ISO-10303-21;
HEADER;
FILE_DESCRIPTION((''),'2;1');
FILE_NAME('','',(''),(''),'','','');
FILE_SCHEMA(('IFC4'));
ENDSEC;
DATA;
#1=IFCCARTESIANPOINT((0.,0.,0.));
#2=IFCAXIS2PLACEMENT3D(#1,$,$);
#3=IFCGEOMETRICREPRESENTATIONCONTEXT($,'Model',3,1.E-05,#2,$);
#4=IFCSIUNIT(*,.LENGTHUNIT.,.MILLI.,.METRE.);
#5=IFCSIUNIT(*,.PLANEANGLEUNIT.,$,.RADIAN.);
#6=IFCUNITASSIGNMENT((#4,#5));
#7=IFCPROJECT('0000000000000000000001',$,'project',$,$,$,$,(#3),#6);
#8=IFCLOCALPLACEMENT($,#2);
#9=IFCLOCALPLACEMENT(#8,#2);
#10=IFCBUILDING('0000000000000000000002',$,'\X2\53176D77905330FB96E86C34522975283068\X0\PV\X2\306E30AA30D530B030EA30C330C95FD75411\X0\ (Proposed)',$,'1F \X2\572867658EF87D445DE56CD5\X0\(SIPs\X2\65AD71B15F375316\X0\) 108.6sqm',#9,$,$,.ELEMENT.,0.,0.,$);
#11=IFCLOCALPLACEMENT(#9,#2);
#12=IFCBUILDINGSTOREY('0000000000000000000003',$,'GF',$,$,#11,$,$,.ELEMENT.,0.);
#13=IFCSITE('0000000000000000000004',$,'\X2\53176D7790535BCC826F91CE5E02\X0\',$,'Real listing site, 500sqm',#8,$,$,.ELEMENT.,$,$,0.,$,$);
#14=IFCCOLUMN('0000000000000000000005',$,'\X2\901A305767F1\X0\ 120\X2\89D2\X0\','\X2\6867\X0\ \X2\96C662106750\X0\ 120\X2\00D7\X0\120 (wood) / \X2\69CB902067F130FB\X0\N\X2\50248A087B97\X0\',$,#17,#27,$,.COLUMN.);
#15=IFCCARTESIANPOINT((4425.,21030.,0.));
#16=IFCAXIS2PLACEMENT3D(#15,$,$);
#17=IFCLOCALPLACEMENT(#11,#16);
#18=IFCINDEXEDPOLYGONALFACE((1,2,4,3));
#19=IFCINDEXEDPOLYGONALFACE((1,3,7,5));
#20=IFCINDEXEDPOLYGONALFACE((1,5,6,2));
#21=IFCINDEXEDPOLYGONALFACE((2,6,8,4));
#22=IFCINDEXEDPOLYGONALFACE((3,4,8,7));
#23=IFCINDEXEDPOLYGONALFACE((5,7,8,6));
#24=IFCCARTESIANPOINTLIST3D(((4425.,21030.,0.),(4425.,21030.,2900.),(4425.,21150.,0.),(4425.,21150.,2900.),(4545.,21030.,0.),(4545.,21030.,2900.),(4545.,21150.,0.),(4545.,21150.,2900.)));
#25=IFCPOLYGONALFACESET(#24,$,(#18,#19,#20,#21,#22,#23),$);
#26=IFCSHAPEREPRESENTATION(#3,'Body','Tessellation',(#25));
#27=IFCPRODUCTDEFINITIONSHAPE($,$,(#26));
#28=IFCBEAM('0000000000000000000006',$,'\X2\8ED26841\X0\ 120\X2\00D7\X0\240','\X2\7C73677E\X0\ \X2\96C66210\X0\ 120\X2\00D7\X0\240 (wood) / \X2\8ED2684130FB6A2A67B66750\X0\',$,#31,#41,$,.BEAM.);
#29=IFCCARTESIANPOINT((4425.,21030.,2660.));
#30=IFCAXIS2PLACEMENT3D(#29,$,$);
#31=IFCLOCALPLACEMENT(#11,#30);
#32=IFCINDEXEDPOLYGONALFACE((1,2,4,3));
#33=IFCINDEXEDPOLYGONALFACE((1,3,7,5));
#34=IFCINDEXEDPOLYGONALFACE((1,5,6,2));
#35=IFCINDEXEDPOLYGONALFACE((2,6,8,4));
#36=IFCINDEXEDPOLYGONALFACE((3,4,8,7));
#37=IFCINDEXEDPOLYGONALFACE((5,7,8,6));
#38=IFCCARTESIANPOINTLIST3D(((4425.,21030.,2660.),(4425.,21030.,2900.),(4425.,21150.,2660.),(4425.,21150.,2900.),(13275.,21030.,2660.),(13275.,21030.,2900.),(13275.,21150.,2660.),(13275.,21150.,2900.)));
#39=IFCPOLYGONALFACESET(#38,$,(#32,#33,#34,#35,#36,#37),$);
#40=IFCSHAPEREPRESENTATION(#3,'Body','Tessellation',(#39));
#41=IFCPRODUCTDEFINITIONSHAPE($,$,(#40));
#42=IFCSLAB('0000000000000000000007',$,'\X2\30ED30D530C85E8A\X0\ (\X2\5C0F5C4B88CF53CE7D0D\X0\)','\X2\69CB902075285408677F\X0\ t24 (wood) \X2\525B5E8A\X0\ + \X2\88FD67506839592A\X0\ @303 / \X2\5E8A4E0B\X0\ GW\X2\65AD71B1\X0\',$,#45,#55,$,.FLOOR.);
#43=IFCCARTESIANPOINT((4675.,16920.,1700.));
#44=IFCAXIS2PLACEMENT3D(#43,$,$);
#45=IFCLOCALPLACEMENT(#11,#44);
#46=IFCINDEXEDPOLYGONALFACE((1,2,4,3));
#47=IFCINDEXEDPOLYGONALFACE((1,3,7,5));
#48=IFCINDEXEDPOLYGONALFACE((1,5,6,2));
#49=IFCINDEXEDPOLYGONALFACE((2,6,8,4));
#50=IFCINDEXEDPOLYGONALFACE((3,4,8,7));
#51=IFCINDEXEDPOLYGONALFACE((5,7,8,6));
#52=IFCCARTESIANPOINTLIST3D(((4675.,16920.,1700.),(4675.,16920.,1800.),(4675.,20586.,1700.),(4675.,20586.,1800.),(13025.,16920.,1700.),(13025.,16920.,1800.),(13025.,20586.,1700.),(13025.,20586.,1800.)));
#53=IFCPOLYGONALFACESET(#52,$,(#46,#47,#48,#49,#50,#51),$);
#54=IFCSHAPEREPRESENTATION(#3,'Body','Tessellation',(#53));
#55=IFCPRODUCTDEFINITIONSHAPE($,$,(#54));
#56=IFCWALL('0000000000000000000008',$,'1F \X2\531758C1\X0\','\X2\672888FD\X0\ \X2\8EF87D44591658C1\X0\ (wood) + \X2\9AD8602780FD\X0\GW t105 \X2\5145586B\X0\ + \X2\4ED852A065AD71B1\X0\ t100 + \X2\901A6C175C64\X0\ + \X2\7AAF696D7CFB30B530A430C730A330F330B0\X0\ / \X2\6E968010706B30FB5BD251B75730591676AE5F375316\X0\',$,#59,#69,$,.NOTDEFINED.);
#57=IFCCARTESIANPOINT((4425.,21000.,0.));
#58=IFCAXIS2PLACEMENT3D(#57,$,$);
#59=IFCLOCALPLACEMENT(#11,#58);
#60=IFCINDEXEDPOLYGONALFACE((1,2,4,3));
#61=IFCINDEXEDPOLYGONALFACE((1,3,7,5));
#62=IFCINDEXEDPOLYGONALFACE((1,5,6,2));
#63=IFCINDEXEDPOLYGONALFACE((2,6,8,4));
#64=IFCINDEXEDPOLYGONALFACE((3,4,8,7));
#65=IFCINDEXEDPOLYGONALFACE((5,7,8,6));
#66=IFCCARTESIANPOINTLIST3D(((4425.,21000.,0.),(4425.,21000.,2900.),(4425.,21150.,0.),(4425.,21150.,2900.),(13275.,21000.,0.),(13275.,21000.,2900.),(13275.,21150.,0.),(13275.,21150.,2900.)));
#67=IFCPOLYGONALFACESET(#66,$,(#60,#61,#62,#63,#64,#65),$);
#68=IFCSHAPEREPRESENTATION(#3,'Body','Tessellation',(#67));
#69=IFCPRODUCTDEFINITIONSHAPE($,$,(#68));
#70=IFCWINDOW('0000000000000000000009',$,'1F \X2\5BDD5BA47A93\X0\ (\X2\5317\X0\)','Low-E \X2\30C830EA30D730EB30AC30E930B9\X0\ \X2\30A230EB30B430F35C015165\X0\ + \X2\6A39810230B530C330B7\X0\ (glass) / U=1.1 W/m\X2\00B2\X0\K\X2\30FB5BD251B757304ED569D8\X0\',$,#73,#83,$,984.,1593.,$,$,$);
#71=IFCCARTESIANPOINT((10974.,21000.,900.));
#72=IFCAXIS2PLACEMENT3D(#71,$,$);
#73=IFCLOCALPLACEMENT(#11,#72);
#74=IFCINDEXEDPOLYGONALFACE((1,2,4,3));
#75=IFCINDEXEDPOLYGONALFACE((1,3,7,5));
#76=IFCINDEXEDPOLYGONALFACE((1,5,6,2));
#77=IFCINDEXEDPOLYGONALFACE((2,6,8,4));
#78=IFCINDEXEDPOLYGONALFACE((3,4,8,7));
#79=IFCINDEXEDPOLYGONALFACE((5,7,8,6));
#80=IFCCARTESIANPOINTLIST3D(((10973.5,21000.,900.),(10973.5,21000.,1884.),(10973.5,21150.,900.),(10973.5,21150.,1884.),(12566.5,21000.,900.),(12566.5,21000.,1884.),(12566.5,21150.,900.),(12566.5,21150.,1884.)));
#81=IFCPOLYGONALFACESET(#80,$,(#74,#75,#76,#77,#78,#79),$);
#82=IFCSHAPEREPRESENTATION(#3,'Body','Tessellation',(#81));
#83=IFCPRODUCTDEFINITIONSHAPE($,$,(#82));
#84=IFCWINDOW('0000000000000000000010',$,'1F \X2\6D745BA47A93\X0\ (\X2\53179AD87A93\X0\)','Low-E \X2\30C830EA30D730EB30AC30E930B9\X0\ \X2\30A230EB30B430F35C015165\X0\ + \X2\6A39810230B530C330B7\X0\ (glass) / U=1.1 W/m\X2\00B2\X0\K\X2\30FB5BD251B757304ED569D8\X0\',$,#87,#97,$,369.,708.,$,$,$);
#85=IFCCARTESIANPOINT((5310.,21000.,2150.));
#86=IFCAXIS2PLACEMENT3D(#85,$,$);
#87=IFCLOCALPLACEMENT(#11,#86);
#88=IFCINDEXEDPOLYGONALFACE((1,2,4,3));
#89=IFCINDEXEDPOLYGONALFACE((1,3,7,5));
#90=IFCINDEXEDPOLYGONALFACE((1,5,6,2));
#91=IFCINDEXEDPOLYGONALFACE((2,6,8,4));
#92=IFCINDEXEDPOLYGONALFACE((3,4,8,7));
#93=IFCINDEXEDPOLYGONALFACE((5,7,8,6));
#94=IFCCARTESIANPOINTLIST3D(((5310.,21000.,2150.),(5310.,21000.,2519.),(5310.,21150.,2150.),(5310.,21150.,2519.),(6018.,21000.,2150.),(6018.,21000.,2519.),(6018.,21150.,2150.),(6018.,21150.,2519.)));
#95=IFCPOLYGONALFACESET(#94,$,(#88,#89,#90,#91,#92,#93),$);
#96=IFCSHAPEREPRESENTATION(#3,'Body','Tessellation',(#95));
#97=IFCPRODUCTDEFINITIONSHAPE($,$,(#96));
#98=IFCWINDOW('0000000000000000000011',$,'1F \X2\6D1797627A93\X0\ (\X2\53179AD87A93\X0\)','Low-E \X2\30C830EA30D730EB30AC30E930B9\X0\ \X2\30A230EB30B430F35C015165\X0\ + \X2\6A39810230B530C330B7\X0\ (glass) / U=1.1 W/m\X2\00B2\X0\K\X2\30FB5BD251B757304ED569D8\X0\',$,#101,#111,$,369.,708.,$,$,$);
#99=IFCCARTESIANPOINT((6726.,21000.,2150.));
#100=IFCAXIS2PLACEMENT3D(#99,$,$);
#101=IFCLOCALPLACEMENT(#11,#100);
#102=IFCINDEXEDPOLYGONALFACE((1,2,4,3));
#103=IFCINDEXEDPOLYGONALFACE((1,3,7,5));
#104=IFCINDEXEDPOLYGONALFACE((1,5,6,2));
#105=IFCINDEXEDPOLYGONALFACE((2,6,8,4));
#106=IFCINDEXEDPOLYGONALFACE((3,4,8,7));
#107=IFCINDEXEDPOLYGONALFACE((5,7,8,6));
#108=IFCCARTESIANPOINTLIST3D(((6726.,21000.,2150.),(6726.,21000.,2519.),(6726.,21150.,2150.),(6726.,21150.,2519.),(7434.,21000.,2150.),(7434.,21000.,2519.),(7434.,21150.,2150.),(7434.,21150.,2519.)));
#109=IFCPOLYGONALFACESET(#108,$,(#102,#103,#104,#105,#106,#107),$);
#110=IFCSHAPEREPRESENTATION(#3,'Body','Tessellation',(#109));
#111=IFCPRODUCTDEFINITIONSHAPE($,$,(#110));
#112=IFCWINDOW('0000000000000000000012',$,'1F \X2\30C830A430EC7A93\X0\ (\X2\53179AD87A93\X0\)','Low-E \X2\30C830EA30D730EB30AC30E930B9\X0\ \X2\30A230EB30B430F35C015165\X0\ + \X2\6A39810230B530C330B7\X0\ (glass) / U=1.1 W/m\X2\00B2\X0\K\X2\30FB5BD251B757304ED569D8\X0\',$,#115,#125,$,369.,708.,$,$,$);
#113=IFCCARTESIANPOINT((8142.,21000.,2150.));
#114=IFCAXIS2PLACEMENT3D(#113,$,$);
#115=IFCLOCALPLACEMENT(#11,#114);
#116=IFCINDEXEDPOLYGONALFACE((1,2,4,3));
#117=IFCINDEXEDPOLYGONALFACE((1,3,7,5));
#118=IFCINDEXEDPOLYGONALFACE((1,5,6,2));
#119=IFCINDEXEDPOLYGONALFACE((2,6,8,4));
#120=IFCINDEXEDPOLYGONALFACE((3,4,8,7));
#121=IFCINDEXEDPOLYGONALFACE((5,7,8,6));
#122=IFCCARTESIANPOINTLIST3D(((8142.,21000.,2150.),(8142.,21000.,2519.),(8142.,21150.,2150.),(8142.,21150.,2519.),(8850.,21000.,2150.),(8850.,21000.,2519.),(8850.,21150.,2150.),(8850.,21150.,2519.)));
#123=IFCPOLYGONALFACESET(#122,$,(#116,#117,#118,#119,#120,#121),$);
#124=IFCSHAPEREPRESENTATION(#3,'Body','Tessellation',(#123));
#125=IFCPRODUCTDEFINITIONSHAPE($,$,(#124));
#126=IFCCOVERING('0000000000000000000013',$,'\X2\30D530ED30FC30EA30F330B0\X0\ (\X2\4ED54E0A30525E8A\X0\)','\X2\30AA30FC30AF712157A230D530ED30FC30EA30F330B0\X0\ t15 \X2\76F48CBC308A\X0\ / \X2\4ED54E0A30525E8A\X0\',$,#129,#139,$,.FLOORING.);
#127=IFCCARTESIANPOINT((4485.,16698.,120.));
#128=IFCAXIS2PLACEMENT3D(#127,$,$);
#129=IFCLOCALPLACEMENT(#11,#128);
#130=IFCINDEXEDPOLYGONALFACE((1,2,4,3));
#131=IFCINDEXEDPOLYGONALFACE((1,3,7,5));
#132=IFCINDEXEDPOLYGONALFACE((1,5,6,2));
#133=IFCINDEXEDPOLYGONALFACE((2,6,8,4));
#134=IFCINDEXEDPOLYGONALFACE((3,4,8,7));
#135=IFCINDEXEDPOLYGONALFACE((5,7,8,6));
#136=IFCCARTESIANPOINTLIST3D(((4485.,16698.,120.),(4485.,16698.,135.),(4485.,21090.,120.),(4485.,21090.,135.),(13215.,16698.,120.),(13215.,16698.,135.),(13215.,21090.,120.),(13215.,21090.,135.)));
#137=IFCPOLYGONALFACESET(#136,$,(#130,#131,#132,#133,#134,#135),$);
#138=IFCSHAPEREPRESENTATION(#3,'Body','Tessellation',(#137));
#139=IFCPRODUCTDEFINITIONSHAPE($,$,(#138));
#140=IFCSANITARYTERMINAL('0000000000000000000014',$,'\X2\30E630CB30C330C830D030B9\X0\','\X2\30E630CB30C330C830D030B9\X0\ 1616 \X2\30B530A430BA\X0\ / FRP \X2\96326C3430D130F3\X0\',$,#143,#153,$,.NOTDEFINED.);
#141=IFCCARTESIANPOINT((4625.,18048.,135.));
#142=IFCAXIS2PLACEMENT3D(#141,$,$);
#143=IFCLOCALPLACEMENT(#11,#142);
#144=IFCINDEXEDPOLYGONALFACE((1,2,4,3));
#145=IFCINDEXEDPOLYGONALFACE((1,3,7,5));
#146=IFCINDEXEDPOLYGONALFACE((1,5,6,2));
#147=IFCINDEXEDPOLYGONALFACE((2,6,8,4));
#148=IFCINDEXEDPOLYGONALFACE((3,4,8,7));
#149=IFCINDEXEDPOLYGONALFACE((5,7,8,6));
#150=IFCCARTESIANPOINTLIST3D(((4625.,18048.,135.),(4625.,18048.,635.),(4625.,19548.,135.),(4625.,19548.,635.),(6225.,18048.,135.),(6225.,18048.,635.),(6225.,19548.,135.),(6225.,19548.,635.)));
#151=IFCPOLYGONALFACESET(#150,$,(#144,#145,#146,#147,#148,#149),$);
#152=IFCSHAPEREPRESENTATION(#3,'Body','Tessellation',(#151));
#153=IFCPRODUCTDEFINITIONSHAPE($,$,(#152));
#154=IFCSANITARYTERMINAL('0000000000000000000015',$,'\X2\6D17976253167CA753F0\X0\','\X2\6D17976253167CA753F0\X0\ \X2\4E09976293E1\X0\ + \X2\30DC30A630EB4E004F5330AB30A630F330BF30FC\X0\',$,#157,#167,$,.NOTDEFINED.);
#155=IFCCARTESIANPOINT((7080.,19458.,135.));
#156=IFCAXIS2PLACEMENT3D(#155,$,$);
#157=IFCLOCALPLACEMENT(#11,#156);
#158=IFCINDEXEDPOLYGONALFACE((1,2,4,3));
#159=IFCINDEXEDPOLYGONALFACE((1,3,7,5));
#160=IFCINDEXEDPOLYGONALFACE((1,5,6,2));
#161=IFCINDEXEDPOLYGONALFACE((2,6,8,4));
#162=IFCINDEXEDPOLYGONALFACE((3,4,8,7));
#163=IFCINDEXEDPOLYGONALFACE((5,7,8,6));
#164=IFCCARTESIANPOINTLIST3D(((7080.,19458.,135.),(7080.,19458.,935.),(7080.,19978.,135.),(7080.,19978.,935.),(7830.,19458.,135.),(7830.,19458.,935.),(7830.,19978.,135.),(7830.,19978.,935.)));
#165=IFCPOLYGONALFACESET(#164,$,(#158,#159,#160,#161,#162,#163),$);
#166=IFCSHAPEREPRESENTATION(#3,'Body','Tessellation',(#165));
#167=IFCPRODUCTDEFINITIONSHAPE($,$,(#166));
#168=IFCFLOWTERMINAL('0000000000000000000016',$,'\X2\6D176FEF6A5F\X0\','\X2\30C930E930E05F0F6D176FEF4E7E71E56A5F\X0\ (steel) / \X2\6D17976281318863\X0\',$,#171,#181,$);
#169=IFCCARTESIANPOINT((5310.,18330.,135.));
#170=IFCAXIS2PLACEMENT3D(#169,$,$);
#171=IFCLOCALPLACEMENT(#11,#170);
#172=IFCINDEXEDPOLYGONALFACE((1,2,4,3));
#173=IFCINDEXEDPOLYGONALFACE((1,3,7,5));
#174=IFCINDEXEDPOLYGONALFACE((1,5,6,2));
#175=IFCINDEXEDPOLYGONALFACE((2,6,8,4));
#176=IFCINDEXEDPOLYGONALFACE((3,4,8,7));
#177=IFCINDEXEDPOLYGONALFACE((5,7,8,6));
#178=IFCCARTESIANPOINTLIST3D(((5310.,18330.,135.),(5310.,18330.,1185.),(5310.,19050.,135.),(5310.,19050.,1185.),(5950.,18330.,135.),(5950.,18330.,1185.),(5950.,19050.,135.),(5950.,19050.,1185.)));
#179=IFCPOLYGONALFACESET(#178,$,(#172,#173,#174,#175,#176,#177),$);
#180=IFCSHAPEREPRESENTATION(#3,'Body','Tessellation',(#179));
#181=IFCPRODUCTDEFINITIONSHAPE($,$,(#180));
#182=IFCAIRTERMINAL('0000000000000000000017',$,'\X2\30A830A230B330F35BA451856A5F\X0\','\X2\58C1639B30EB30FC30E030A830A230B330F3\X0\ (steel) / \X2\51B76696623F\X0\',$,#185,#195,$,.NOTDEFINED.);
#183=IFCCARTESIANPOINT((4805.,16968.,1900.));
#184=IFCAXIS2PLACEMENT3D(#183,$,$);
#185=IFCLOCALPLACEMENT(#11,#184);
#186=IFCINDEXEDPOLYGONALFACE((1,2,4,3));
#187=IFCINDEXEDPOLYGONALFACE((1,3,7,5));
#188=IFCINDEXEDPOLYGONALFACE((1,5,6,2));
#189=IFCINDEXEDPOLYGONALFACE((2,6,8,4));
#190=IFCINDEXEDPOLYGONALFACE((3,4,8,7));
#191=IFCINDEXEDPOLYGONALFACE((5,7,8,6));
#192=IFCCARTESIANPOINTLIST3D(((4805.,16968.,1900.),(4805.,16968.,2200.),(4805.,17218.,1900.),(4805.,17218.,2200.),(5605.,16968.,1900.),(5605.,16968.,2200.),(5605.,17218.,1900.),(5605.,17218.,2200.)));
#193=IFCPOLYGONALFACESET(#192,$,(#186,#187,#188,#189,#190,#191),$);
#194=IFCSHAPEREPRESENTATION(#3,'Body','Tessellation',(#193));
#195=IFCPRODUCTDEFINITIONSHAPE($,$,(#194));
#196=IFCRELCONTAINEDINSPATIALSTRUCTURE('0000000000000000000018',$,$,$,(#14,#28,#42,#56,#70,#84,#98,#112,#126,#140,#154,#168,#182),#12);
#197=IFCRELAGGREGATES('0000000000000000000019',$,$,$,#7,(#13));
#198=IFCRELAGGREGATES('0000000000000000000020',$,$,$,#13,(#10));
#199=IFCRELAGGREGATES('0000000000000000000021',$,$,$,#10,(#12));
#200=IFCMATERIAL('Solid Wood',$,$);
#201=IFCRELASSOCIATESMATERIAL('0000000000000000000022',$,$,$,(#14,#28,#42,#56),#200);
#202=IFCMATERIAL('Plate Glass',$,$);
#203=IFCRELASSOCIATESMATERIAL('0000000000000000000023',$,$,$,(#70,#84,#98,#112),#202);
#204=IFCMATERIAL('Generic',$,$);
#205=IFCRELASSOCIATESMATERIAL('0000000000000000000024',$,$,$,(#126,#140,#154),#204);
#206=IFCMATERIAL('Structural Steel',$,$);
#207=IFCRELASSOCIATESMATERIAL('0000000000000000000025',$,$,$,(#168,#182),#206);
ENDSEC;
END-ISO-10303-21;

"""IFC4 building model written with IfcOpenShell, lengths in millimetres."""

from ifc_helpers import new_model, si_unit, frame, frame_2d, origin, place, context, project, spatial, rectangle, extrude, material, element, fill, save


model = new_model("IFC4")

# Units and contexts
model_context = context("Model", 3, precision=1e-05, world=origin())
ifc_project = project(units=[si_unit("LENGTHUNIT", "METRE", prefix="MILLI"), si_unit("PLANEANGLEUNIT", "RADIAN")], contexts=[model_context])

# Site, building, storey
site_placement = place(None, origin())
site = spatial("IfcSite", under=ifc_project, at=site_placement, Name="北海道富良野市", ObjectType="Real listing site, 500sqm", CompositionType="ELEMENT", RefElevation=0.0)
building_placement = place(site_placement, origin())
building = spatial("IfcBuilding", under=site, at=building_placement, Name="北海道・雨水利用とPVのオフグリッド志向 (Proposed)", ObjectType="1F 在来軸組工法(SIPs断熱強化) 108.6sqm", CompositionType="ELEMENT", ElevationOfRefHeight=0.0, ElevationOfTerrain=0.0)
storey_placement = place(building_placement, origin())
storey = spatial("IfcBuildingStorey", under=building, at=storey_placement, Name="GF", CompositionType="ELEMENT", Elevation=0.0)

# Column
ifc_material_1 = material(Name="Solid Wood")
column_1_placement = place(storey_placement, frame((4425.0, 21030.0, 0.0)))
element("IfcColumn", 1, at=column_1_placement, inside=storey, material=ifc_material_1, Name="通し柱 120角", Description="桧 集成材 120×120 (wood) / 構造柱・N値計算", PredefinedType="COLUMN", context=model_context, shape_type="SweptSolid", body=[
    extrude(rectangle(XDim=120.0, YDim=120.0, at=frame_2d((60.0, 60.0))), frame((4425.0, 21030.0, 0.0)), (0.0, 0.0, 1.0), 2900.0),
])

# Beam
beam_1_placement = place(storey_placement, frame((4425.0, 21030.0, 2660.0)))
element("IfcBeam", 2, at=beam_1_placement, inside=storey, material=ifc_material_1, Name="軒桁 120×240", Description="米松 集成 120×240 (wood) / 軒桁・横架材", PredefinedType="BEAM", context=model_context, shape_type="SweptSolid", body=[
    extrude(rectangle(XDim=8850.0, YDim=120.0, at=frame_2d((4425.0, 60.0))), frame((4425.0, 21030.0, 2660.0)), (0.0, 0.0, 1.0), 240.0),
])

# Slab
slab_placement = place(storey_placement, frame((4675.0, 16920.0, 1700.0)))
element("IfcSlab", 3, at=slab_placement, inside=storey, material=ifc_material_1, Name="ロフト床 (小屋裏収納)", Description="構造用合板 t24 (wood) 剛床 + 製材根太 @303 / 床下 GW断熱", PredefinedType="FLOOR", context=model_context, shape_type="SweptSolid", body=[
    extrude(rectangle(XDim=8350.0, YDim=3666.0, at=frame_2d((4175.0, 1833.0))), frame((4675.0, 16920.0, 1700.0)), (0.0, 0.0, 1.0), 100.0),
])

# Wall, openings, windows
wall_1_placement = place(storey_placement, frame((4425.0, 21000.0, 0.0)))
wall_1 = element("IfcWall", 4, at=wall_1_placement, inside=storey, material=ifc_material_1, Name="1F 北壁", Description="木製 軸組外壁 (wood) + 高性能GW t105 充填 + 付加断熱 t100 + 通気層 + 窯業系サイディング / 準耐火・寒冷地外皮強化", PredefinedType="NOTDEFINED", context=model_context, shape_type="SweptSolid", body=[
    extrude(rectangle(XDim=8850.0, YDim=150.0, at=frame_2d((4425.0, 75.0))), frame((4425.0, 21000.0, 0.0)), (0.0, 0.0, 1.0), 2900.0),
])
opening_1_placement = place(storey_placement, frame((10974.0, 21000.0, 900.0)))
opening_1 = element("IfcOpeningElement", 5, at=opening_1_placement, cuts=wall_1, PredefinedType="NOTDEFINED", context=model_context, shape_type="SweptSolid", body=[
    extrude(rectangle(XDim=1593.0, YDim=150.0, at=frame_2d((796.0, 75.0))), frame((10974.0, 21000.0, 900.0)), (0.0, 0.0, 1.0), 984.0),
])
opening_2_placement = place(storey_placement, frame((5310.0, 21000.0, 2150.0)))
opening_2 = element("IfcOpeningElement", 6, at=opening_2_placement, cuts=wall_1, PredefinedType="NOTDEFINED", context=model_context, shape_type="SweptSolid", body=[
    extrude(rectangle(XDim=708.0, YDim=150.0, at=frame_2d((354.0, 75.0))), frame((5310.0, 21000.0, 2150.0)), (0.0, 0.0, 1.0), 369.0),
])
opening_3_placement = place(storey_placement, frame((6726.0, 21000.0, 2150.0)))
opening_3 = element("IfcOpeningElement", 7, at=opening_3_placement, cuts=wall_1, PredefinedType="NOTDEFINED", context=model_context, shape_type="SweptSolid", body=[
    extrude(rectangle(XDim=708.0, YDim=150.0, at=frame_2d((354.0, 75.0))), frame((6726.0, 21000.0, 2150.0)), (0.0, 0.0, 1.0), 369.0),
])
opening_4_placement = place(storey_placement, frame((8142.0, 21000.0, 2150.0)))
opening_4 = element("IfcOpeningElement", 8, at=opening_4_placement, cuts=wall_1, PredefinedType="NOTDEFINED", context=model_context, shape_type="SweptSolid", body=[
    extrude(rectangle(XDim=708.0, YDim=150.0, at=frame_2d((354.0, 75.0))), frame((8142.0, 21000.0, 2150.0)), (0.0, 0.0, 1.0), 369.0),
])
ifc_material_2 = material(Name="Plate Glass")
window_1_placement = place(storey_placement, frame((10974.0, 21000.0, 900.0)))
window_1 = element("IfcWindow", 9, at=window_1_placement, inside=storey, material=ifc_material_2, Name="1F 寝室窓 (北)", Description="Low-E トリプルガラス アルゴン封入 + 樹脂サッシ (glass) / U=1.1 W/m²K・寒冷地仕様", OverallHeight=984.0, OverallWidth=1593.0, context=model_context, shape_type="SweptSolid", body=[
    extrude(rectangle(XDim=1593.0, YDim=150.0, at=frame_2d((796.0, 75.0))), frame((10974.0, 21000.0, 900.0)), (0.0, 0.0, 1.0), 984.0),
])
fill(opening_1, window_1)
window_2_placement = place(storey_placement, frame((5310.0, 21000.0, 2150.0)))
window_2 = element("IfcWindow", 10, at=window_2_placement, inside=storey, material=ifc_material_2, Name="1F 浴室窓 (北高窓)", Description="Low-E トリプルガラス アルゴン封入 + 樹脂サッシ (glass) / U=1.1 W/m²K・寒冷地仕様", OverallHeight=369.0, OverallWidth=708.0, context=model_context, shape_type="SweptSolid", body=[
    extrude(rectangle(XDim=708.0, YDim=150.0, at=frame_2d((354.0, 75.0))), frame((5310.0, 21000.0, 2150.0)), (0.0, 0.0, 1.0), 369.0),
])
fill(opening_2, window_2)
window_3_placement = place(storey_placement, frame((6726.0, 21000.0, 2150.0)))
window_3 = element("IfcWindow", 11, at=window_3_placement, inside=storey, material=ifc_material_2, Name="1F 洗面窓 (北高窓)", Description="Low-E トリプルガラス アルゴン封入 + 樹脂サッシ (glass) / U=1.1 W/m²K・寒冷地仕様", OverallHeight=369.0, OverallWidth=708.0, context=model_context, shape_type="SweptSolid", body=[
    extrude(rectangle(XDim=708.0, YDim=150.0, at=frame_2d((354.0, 75.0))), frame((6726.0, 21000.0, 2150.0)), (0.0, 0.0, 1.0), 369.0),
])
fill(opening_3, window_3)
window_4_placement = place(storey_placement, frame((8142.0, 21000.0, 2150.0)))
window_4 = element("IfcWindow", 12, at=window_4_placement, inside=storey, material=ifc_material_2, Name="1F トイレ窓 (北高窓)", Description="Low-E トリプルガラス アルゴン封入 + 樹脂サッシ (glass) / U=1.1 W/m²K・寒冷地仕様", OverallHeight=369.0, OverallWidth=708.0, context=model_context, shape_type="SweptSolid", body=[
    extrude(rectangle(XDim=708.0, YDim=150.0, at=frame_2d((354.0, 75.0))), frame((8142.0, 21000.0, 2150.0)), (0.0, 0.0, 1.0), 369.0),
])
fill(opening_4, window_4)

# Covering
ifc_material_3 = material(Name="Generic")
covering_placement = place(storey_placement, frame((4485.0, 16698.0, 120.0)))
element("IfcCovering", 13, at=covering_placement, inside=storey, material=ifc_material_3, Name="フローリング (仕上げ床)", Description="オーク無垢フローリング t15 直貼り / 仕上げ床", PredefinedType="FLOORING", context=model_context, shape_type="SweptSolid", body=[
    extrude(rectangle(XDim=8730.0, YDim=4392.0, at=frame_2d((4365.0, 2196.0))), frame((4485.0, 16698.0, 120.0)), (0.0, 0.0, 1.0), 15.0),
])

# Sanitary terminals
sanitary_terminal_1_placement = place(storey_placement, frame((4625.0, 18048.0, 135.0)))
element("IfcSanitaryTerminal", 14, at=sanitary_terminal_1_placement, inside=storey, material=ifc_material_3, Name="ユニットバス", Description="ユニットバス 1616 サイズ / FRP 防水パン", PredefinedType="NOTDEFINED", context=model_context, shape_type="SweptSolid", body=[
    extrude(rectangle(XDim=1600.0, YDim=1500.0, at=frame_2d((800.0, 750.0))), frame((4625.0, 18048.0, 135.0)), (0.0, 0.0, 1.0), 500.0),
])
sanitary_terminal_2_placement = place(storey_placement, frame((7080.0, 19458.0, 135.0)))
element("IfcSanitaryTerminal", 15, at=sanitary_terminal_2_placement, inside=storey, material=ifc_material_3, Name="洗面化粧台", Description="洗面化粧台 三面鏡 + ボウル一体カウンター", PredefinedType="NOTDEFINED", context=model_context, shape_type="SweptSolid", body=[
    extrude(rectangle(XDim=750.0, YDim=520.0, at=frame_2d((375.0, 260.0))), frame((7080.0, 19458.0, 135.0)), (0.0, 0.0, 1.0), 800.0),
])

# Flow terminal
ifc_material_4 = material(Name="Structural Steel")
flow_terminal_placement = place(storey_placement, frame((5310.0, 18330.0, 135.0)))
element("IfcFlowTerminal", 16, at=flow_terminal_placement, inside=storey, material=ifc_material_4, Name="洗濯機", Description="ドラム式洗濯乾燥機 (steel) / 洗面脱衣", context=model_context, shape_type="SweptSolid", body=[
    extrude(rectangle(XDim=640.0, YDim=720.0, at=frame_2d((320.0, 360.0))), frame((5310.0, 18330.0, 135.0)), (0.0, 0.0, 1.0), 1050.0),
])

# Air terminal
air_terminal_placement = place(storey_placement, frame((4805.0, 16968.0, 1900.0)))
element("IfcAirTerminal", 17, at=air_terminal_placement, inside=storey, material=ifc_material_4, Name="エアコン室内機", Description="壁掛ルームエアコン (steel) / 冷暖房", PredefinedType="NOTDEFINED", context=model_context, shape_type="SweptSolid", body=[
    extrude(rectangle(XDim=800.0, YDim=250.0, at=frame_2d((400.0, 125.0))), frame((4805.0, 16968.0, 1900.0)), (0.0, 0.0, 1.0), 300.0),
])

save(model, "model.ifc")
